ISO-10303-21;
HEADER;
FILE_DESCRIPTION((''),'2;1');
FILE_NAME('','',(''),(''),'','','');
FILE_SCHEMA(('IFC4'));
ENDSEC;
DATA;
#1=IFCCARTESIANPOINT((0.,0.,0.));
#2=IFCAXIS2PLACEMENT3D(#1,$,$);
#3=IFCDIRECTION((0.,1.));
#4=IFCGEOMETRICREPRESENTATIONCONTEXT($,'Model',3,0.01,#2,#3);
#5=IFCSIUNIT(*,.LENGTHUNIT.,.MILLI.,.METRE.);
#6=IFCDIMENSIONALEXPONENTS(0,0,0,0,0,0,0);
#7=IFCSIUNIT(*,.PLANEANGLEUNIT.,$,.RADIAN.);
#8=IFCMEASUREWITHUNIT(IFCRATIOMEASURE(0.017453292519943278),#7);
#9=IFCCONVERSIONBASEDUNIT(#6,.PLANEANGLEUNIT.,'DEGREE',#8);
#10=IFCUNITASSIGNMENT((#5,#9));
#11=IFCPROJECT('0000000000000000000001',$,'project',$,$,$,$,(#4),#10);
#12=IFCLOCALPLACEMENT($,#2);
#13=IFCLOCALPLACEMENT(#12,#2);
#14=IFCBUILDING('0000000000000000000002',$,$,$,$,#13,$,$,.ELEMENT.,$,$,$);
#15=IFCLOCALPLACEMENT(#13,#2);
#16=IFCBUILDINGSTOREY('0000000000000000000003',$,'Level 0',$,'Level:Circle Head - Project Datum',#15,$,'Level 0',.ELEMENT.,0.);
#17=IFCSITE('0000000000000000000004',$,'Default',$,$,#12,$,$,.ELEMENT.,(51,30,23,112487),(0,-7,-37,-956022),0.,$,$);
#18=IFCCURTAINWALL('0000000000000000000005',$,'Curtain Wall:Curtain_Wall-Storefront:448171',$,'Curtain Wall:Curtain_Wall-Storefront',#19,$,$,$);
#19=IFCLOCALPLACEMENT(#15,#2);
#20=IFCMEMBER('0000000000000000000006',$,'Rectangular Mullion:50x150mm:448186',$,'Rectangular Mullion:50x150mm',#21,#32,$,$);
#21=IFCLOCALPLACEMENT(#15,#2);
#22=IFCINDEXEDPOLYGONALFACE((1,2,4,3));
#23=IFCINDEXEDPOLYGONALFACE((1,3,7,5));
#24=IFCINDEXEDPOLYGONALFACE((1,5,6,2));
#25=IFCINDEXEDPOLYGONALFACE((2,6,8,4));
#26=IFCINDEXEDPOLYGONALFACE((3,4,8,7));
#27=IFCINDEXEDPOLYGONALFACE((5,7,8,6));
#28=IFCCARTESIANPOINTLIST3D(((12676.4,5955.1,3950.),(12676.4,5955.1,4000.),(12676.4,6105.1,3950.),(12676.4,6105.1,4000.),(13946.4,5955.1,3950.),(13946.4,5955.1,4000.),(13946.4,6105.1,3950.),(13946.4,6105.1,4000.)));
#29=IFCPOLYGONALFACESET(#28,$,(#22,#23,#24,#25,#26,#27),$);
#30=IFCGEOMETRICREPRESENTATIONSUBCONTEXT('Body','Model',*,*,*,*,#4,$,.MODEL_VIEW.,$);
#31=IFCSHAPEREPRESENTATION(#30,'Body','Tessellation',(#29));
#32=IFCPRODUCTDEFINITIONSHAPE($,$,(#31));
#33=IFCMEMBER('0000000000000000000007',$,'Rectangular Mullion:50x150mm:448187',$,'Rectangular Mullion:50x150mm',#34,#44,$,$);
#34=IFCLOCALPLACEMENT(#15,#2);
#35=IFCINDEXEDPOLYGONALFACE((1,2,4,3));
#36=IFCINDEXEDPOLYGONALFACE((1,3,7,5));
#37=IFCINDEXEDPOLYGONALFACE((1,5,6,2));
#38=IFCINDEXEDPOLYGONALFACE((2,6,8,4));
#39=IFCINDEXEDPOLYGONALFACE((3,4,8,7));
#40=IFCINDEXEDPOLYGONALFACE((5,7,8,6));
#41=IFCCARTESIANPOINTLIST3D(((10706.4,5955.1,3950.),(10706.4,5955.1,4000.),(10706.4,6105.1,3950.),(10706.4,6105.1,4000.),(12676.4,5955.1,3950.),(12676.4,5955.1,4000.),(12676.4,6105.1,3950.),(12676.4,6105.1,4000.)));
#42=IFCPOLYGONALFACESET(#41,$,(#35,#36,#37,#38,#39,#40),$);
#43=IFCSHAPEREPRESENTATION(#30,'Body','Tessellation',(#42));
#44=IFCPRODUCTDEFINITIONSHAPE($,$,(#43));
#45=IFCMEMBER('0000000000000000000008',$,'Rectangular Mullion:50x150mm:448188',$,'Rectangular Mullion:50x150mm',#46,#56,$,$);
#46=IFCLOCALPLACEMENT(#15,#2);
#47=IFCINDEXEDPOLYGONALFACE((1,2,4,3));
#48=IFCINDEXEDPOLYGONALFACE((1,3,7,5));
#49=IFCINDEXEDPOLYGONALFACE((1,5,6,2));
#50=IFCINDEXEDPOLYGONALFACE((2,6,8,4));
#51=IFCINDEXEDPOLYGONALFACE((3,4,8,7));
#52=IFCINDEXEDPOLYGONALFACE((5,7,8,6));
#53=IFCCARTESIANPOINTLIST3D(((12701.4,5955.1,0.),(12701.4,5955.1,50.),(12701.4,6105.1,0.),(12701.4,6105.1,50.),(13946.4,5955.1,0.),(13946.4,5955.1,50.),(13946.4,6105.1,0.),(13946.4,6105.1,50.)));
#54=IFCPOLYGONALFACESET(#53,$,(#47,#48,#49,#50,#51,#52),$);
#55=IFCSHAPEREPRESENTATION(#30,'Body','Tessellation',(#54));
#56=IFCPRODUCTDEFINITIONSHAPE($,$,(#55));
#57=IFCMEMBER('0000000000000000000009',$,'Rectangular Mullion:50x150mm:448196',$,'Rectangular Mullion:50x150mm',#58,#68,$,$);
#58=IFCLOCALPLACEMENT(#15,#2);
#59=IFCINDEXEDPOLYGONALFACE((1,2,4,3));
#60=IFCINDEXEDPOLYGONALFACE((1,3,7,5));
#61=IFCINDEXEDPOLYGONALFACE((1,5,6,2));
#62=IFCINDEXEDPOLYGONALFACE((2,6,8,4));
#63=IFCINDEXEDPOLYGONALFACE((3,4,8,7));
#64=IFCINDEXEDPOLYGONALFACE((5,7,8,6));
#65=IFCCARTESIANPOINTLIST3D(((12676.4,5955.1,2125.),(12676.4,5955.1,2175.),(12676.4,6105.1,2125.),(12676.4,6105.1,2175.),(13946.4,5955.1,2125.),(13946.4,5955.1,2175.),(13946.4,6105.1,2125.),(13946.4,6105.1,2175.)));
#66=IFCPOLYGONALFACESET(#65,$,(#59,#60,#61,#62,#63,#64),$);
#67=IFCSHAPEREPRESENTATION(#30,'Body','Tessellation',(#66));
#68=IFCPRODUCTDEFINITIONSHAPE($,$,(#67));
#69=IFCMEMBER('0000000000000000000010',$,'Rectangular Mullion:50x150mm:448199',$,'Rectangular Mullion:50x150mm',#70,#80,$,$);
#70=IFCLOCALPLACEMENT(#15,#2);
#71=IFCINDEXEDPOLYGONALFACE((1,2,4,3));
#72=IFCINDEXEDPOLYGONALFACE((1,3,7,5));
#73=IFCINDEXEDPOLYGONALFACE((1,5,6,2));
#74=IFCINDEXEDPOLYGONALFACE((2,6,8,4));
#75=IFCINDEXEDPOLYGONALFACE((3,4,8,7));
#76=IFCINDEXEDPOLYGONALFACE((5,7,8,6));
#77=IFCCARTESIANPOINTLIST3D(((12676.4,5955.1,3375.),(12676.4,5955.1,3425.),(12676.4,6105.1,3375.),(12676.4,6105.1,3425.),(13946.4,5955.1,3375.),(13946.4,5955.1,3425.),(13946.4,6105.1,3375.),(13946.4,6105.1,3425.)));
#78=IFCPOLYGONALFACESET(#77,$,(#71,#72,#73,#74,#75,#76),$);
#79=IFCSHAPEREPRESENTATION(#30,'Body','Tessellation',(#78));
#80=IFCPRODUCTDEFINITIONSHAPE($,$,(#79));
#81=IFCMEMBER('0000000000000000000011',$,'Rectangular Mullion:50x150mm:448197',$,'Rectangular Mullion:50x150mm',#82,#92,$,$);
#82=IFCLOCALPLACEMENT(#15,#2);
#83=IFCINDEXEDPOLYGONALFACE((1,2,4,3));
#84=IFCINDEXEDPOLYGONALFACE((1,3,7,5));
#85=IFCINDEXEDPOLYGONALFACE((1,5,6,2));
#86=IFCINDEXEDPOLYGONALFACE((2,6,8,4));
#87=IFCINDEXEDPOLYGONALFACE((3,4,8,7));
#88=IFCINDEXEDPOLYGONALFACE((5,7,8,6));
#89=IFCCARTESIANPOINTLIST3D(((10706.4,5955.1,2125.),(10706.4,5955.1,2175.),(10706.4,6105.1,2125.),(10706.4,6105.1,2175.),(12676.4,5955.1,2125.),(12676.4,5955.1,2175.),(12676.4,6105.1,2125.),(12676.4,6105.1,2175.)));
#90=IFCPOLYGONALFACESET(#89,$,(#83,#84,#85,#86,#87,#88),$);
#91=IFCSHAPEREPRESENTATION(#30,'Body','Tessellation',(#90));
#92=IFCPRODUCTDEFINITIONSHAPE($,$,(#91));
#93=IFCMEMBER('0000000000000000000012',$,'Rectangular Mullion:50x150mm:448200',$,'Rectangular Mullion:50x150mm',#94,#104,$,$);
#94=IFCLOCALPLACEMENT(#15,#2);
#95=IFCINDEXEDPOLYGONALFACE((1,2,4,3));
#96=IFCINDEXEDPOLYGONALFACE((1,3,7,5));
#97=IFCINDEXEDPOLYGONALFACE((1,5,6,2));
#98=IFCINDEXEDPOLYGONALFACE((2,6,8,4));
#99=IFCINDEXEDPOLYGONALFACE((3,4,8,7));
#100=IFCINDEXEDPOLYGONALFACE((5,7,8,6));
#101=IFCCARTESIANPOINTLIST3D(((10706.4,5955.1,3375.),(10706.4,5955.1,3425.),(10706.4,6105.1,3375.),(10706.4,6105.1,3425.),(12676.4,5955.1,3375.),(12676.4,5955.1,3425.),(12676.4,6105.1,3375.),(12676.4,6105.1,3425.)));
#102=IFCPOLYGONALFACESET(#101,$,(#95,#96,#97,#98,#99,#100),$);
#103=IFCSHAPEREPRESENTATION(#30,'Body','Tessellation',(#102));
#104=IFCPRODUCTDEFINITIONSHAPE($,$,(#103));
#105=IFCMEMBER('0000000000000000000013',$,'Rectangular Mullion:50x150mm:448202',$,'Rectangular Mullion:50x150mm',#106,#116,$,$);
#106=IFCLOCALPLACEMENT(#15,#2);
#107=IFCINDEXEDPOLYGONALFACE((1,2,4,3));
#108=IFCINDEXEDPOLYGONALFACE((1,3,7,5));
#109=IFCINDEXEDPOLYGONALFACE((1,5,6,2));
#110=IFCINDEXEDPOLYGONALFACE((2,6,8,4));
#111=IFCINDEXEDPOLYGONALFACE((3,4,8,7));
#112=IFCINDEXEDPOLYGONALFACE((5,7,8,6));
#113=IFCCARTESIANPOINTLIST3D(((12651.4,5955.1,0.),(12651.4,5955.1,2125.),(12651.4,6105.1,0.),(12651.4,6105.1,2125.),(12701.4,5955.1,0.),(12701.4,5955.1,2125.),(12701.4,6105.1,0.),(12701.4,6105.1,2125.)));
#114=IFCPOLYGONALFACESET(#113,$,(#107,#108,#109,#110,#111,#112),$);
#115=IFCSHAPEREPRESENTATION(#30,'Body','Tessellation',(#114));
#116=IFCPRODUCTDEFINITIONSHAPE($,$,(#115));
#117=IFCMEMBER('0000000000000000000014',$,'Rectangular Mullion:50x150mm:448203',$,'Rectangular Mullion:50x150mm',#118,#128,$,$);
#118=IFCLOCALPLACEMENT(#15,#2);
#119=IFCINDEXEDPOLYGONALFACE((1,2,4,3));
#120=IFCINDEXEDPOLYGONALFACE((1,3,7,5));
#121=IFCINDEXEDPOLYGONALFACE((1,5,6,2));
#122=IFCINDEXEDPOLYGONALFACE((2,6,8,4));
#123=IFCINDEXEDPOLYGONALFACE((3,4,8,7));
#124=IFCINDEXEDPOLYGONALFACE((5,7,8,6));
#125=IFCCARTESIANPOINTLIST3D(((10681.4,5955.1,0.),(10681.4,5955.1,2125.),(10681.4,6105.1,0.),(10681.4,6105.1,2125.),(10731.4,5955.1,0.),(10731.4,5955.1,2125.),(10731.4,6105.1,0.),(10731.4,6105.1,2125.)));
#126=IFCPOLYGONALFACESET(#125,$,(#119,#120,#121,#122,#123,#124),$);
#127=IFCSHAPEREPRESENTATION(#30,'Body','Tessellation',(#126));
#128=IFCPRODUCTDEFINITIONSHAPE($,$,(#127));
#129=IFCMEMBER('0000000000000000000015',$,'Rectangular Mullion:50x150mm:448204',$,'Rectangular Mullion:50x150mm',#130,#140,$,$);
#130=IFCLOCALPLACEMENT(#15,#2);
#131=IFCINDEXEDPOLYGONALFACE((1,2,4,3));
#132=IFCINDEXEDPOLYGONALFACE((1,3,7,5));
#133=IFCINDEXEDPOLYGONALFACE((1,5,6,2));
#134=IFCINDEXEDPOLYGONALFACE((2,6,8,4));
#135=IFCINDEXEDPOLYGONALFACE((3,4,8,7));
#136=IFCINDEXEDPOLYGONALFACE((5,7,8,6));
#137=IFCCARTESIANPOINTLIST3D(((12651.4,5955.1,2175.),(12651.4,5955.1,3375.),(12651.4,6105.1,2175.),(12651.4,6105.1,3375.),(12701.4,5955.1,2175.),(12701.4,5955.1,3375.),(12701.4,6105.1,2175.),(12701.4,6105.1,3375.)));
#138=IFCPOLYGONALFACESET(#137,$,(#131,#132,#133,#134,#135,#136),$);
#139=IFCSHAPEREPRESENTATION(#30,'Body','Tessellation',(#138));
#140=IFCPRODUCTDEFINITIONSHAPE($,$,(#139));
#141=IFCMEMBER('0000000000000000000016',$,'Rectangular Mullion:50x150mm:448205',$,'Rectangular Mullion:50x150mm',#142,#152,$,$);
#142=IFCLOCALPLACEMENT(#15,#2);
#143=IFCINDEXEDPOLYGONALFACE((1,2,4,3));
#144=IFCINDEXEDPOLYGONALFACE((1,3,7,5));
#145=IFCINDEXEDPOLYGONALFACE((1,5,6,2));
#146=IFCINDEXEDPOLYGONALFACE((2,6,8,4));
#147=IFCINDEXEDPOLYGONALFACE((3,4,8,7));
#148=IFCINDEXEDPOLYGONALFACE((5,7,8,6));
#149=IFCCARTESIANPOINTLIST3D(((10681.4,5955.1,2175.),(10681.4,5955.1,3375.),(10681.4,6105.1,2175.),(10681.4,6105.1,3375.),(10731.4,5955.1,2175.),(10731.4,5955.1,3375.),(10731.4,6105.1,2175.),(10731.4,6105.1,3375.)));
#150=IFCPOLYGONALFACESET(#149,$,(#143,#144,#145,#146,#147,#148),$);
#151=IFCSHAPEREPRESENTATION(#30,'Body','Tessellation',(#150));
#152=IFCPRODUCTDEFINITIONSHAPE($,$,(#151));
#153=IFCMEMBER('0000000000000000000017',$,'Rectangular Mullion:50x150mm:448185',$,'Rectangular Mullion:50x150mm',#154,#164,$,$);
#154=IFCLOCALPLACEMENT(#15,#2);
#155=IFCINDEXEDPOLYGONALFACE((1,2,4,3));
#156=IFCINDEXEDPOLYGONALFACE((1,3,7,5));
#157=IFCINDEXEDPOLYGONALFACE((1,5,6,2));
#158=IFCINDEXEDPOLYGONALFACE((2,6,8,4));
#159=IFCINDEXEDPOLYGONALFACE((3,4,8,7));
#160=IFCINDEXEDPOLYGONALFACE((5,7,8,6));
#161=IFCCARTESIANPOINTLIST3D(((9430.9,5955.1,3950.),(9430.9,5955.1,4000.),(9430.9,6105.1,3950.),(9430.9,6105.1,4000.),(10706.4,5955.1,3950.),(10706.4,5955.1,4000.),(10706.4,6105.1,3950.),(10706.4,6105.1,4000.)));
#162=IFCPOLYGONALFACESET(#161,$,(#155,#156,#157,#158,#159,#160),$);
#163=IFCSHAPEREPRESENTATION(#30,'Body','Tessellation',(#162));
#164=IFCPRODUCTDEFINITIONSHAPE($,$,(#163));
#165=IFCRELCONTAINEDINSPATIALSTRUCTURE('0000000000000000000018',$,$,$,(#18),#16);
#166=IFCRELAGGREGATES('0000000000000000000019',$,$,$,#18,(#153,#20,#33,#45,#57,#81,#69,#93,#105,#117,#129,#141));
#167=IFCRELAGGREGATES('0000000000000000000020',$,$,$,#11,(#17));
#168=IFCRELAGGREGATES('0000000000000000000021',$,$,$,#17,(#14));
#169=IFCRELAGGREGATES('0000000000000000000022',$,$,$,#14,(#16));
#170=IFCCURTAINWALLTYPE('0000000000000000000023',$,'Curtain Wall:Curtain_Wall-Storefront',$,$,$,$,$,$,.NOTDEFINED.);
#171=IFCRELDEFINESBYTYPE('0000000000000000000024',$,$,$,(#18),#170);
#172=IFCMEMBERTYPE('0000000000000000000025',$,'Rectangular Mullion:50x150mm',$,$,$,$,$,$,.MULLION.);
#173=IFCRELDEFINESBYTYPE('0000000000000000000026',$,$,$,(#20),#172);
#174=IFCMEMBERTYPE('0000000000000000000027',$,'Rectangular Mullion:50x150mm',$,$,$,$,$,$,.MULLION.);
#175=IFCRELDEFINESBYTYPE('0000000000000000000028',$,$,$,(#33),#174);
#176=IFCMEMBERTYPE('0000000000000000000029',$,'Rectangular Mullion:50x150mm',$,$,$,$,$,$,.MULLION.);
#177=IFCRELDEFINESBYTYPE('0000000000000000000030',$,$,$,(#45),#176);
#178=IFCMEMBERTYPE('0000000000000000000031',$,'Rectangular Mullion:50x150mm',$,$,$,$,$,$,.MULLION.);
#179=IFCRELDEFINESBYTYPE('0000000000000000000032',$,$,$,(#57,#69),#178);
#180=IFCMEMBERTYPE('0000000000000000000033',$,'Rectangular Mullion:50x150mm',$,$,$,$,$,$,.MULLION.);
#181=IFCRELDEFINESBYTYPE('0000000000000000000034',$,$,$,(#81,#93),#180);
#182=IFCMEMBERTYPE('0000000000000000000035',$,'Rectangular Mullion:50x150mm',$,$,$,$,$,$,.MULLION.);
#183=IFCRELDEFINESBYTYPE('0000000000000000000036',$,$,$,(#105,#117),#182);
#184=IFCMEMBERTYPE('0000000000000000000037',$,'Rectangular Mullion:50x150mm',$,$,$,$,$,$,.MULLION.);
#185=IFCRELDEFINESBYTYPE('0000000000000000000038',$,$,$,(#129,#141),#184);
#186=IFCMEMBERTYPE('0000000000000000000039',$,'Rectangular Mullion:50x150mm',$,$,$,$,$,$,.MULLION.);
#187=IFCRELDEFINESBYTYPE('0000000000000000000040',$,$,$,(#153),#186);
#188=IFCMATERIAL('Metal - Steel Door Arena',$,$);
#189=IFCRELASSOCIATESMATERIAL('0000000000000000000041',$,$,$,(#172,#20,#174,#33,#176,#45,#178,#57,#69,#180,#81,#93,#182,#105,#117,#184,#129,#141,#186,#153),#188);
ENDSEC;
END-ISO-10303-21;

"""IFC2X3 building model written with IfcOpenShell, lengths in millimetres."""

from ifc_helpers import new_model, entity, si_unit, converted_unit, direction, frame, origin, origin_2d_with_axis, place, context, subcontext, project, spatial, rectangle, extrude, source, transform, mapped, material, type_object, type_shapes, element, aggregate, save


model = new_model("IFC2X3")

# Units and contexts
model_context = context("Model", 3, precision=0.01, world=origin(), true_north=direction((0.0, 1.0)))
body_context = subcontext(model_context, "Body", "Model", "MODEL_VIEW")
ifc_project = project(units=[si_unit("LENGTHUNIT", "METRE", prefix="MILLI"), converted_unit("PLANEANGLEUNIT", "DEGREE", entity("IfcRatioMeasure", 0.017453292519943278), si_unit("PLANEANGLEUNIT", "RADIAN"), dimensions=[0, 0, 0, 0, 0, 0, 0])], contexts=[model_context])

# Site, building, storey
site_placement = place(None, origin())
site = spatial("IfcSite", under=ifc_project, at=site_placement, Name="Default", CompositionType="ELEMENT", RefLatitude=(51, 30, 23, 112487), RefLongitude=(0, -7, -37, -956022), RefElevation=0.0)
building_placement = place(site_placement, origin())
building = spatial("IfcBuilding", under=site, at=building_placement, CompositionType="ELEMENT")
storey_placement = place(building_placement, origin())
storey = spatial("IfcBuildingStorey", under=building, at=storey_placement, Name="Level 0", ObjectType="Level:Circle Head - Project Datum", LongName="Level 0", CompositionType="ELEMENT", Elevation=0.0)

# Curtain wall, members
curtain_wall_type = type_object("IfcCurtainWallType", Name="Curtain Wall:Curtain_Wall-Storefront", PredefinedType="NOTDEFINED")
curtain_wall_placement = place(storey_placement, origin())
curtain_wall = element("IfcCurtainWall", 1, at=curtain_wall_placement, inside=storey, type_object=curtain_wall_type, Name="Curtain Wall:Curtain_Wall-Storefront:448171", ObjectType="Curtain Wall:Curtain_Wall-Storefront")
ifc_material_1 = material(Name="Metal - Steel Door Arena")
member_type_1 = type_object("IfcMemberType", Name="Rectangular Mullion:50x150mm", PredefinedType="MULLION", material=ifc_material_1)
shared_shape_1 = source(origin(), body_context, "Body", "SweptSolid", [
    extrude(rectangle(XDim=150.0, YDim=50.0, at=origin_2d_with_axis()), frame((-25.0, 0.0, -1270.0), z_axis=(0.0, 0.0, 1.0), x_axis=(0.0, -1.0, 0.0)), (0.0, 0.0, 1.0), 1270.0),
])
type_shapes(member_type_1, [shared_shape_1])
member_1_placement = place(curtain_wall_placement, frame((12676.4, 6030.1, 4000.0), z_axis=(-1.0, 0.0, 0.0), x_axis=(0.0, 0.0, 1.0)))
member_1 = element("IfcMember", 2, at=member_1_placement, type_object=member_type_1, material=ifc_material_1, Name="Rectangular Mullion:50x150mm:448186", ObjectType="Rectangular Mullion:50x150mm", context=body_context, shape_type="MappedRepresentation", body=[
    mapped(shared_shape_1, transform((0.0, 0.0, 0.0), scale=1.0)),
])
member_type_2 = type_object("IfcMemberType", Name="Rectangular Mullion:50x150mm", PredefinedType="MULLION", material=ifc_material_1)
shared_shape_2 = source(origin(), body_context, "Body", "SweptSolid", [
    extrude(rectangle(XDim=150.0, YDim=50.0, at=origin_2d_with_axis()), frame((-25.0, 0.0, -1970.0), z_axis=(0.0, 0.0, 1.0), x_axis=(0.0, -1.0, 0.0)), (0.0, 0.0, 1.0), 1970.0),
])
type_shapes(member_type_2, [shared_shape_2])
member_2_placement = place(curtain_wall_placement, frame((10706.4, 6030.1, 4000.0), z_axis=(-1.0, 0.0, 0.0), x_axis=(0.0, 0.0, 1.0)))
member_2 = element("IfcMember", 3, at=member_2_placement, type_object=member_type_2, material=ifc_material_1, Name="Rectangular Mullion:50x150mm:448187", ObjectType="Rectangular Mullion:50x150mm", context=body_context, shape_type="MappedRepresentation", body=[
    mapped(shared_shape_2, transform((0.0, 0.0, 0.0), scale=1.0)),
])
member_type_3 = type_object("IfcMemberType", Name="Rectangular Mullion:50x150mm", PredefinedType="MULLION", material=ifc_material_1)
shared_shape_3 = source(origin(), body_context, "Body", "SweptSolid", [
    extrude(rectangle(XDim=150.0, YDim=50.0, at=origin_2d_with_axis()), frame((-25.0, 0.0, -1245.0), z_axis=(0.0, 0.0, 1.0), x_axis=(0.0, -1.0, 0.0)), (0.0, 0.0, 1.0), 1245.0),
])
type_shapes(member_type_3, [shared_shape_3])
member_3_placement = place(curtain_wall_placement, frame((13946.4, 6030.1, 0.0), z_axis=(1.0, 0.0, 0.0), x_axis=(0.0, 0.0, -1.0)))
member_3 = element("IfcMember", 4, at=member_3_placement, type_object=member_type_3, material=ifc_material_1, Name="Rectangular Mullion:50x150mm:448188", ObjectType="Rectangular Mullion:50x150mm", context=body_context, shape_type="MappedRepresentation", body=[
    mapped(shared_shape_3, transform((0.0, 0.0, 0.0), scale=1.0)),
])
member_type_4 = type_object("IfcMemberType", Name="Rectangular Mullion:50x150mm", PredefinedType="MULLION", material=ifc_material_1)
shared_shape_4 = source(origin(), body_context, "Body", "SweptSolid", [
    extrude(rectangle(XDim=150.0, YDim=50.0, at=origin_2d_with_axis()), frame((0.0, 0.0, -1270.0), z_axis=(0.0, 0.0, 1.0), x_axis=(0.0, -1.0, 0.0)), (0.0, 0.0, 1.0), 1270.0),
])
type_shapes(member_type_4, [shared_shape_4])
member_4_placement = place(curtain_wall_placement, frame((12676.4, 6030.1, 2150.0), z_axis=(-1.0, 0.0, 0.0), x_axis=(0.0, 0.0, 1.0)))
member_4 = element("IfcMember", 5, at=member_4_placement, type_object=member_type_4, material=ifc_material_1, Name="Rectangular Mullion:50x150mm:448196", ObjectType="Rectangular Mullion:50x150mm", context=body_context, shape_type="MappedRepresentation", body=[
    mapped(shared_shape_4, transform((0.0, 0.0, 0.0), scale=1.0)),
])
member_5_placement = place(curtain_wall_placement, frame((12676.4, 6030.1, 3400.0), z_axis=(-1.0, 0.0, 0.0), x_axis=(0.0, 0.0, 1.0)))
member_5 = element("IfcMember", 6, at=member_5_placement, type_object=member_type_4, material=ifc_material_1, Name="Rectangular Mullion:50x150mm:448199", ObjectType="Rectangular Mullion:50x150mm", context=body_context, shape_type="MappedRepresentation", body=[
    mapped(shared_shape_4, transform((0.0, 0.0, 0.0), scale=1.0)),
])
member_type_5 = type_object("IfcMemberType", Name="Rectangular Mullion:50x150mm", PredefinedType="MULLION", material=ifc_material_1)
shared_shape_5 = source(origin(), body_context, "Body", "SweptSolid", [
    extrude(rectangle(XDim=150.0, YDim=50.0, at=origin_2d_with_axis()), frame((0.0, 0.0, -1970.0), z_axis=(0.0, 0.0, 1.0), x_axis=(0.0, -1.0, 0.0)), (0.0, 0.0, 1.0), 1970.0),
])
type_shapes(member_type_5, [shared_shape_5])
member_6_placement = place(curtain_wall_placement, frame((10706.4, 6030.1, 2150.0), z_axis=(-1.0, 0.0, 0.0), x_axis=(0.0, 0.0, 1.0)))
member_6 = element("IfcMember", 7, at=member_6_placement, type_object=member_type_5, material=ifc_material_1, Name="Rectangular Mullion:50x150mm:448197", ObjectType="Rectangular Mullion:50x150mm", context=body_context, shape_type="MappedRepresentation", body=[
    mapped(shared_shape_5, transform((0.0, 0.0, 0.0), scale=1.0)),
])
member_7_placement = place(curtain_wall_placement, frame((10706.4, 6030.1, 3400.0), z_axis=(-1.0, 0.0, 0.0), x_axis=(0.0, 0.0, 1.0)))
member_7 = element("IfcMember", 8, at=member_7_placement, type_object=member_type_5, material=ifc_material_1, Name="Rectangular Mullion:50x150mm:448200", ObjectType="Rectangular Mullion:50x150mm", context=body_context, shape_type="MappedRepresentation", body=[
    mapped(shared_shape_5, transform((0.0, 0.0, 0.0), scale=1.0)),
])
member_type_6 = type_object("IfcMemberType", Name="Rectangular Mullion:50x150mm", PredefinedType="MULLION", material=ifc_material_1)
shared_shape_6 = source(origin(), body_context, "Body", "SweptSolid", [
    extrude(rectangle(XDim=150.0, YDim=50.0, at=origin_2d_with_axis()), frame((0.0, 0.0, -2125.0), z_axis=(0.0, 0.0, 1.0), x_axis=(0.0, -1.0, 0.0)), (0.0, 0.0, 1.0), 2125.0),
])
type_shapes(member_type_6, [shared_shape_6])
member_8_placement = place(curtain_wall_placement, frame((12676.4, 6030.1, 0.0), z_axis=(0.0, 0.0, -1.0), x_axis=(-1.0, 0.0, 0.0)))
member_8 = element("IfcMember", 9, at=member_8_placement, type_object=member_type_6, material=ifc_material_1, Name="Rectangular Mullion:50x150mm:448202", ObjectType="Rectangular Mullion:50x150mm", context=body_context, shape_type="MappedRepresentation", body=[
    mapped(shared_shape_6, transform((0.0, 0.0, 0.0), scale=1.0)),
])
member_9_placement = place(curtain_wall_placement, frame((10706.4, 6030.1, 0.0), z_axis=(0.0, 0.0, -1.0), x_axis=(-1.0, 0.0, 0.0)))
member_9 = element("IfcMember", 10, at=member_9_placement, type_object=member_type_6, material=ifc_material_1, Name="Rectangular Mullion:50x150mm:448203", ObjectType="Rectangular Mullion:50x150mm", context=body_context, shape_type="MappedRepresentation", body=[
    mapped(shared_shape_6, transform((0.0, 0.0, 0.0), scale=1.0)),
])
member_type_7 = type_object("IfcMemberType", Name="Rectangular Mullion:50x150mm", PredefinedType="MULLION", material=ifc_material_1)
shared_shape_7 = source(origin(), body_context, "Body", "SweptSolid", [
    extrude(rectangle(XDim=150.0, YDim=50.0, at=origin_2d_with_axis()), frame((0.0, 0.0, -1200.0), z_axis=(0.0, 0.0, 1.0), x_axis=(0.0, -1.0, 0.0)), (0.0, 0.0, 1.0), 1200.0),
])
type_shapes(member_type_7, [shared_shape_7])
member_10_placement = place(curtain_wall_placement, frame((12676.4, 6030.1, 2175.0), z_axis=(0.0, 0.0, -1.0), x_axis=(-1.0, 0.0, 0.0)))
member_10 = element("IfcMember", 11, at=member_10_placement, type_object=member_type_7, material=ifc_material_1, Name="Rectangular Mullion:50x150mm:448204", ObjectType="Rectangular Mullion:50x150mm", context=body_context, shape_type="MappedRepresentation", body=[
    mapped(shared_shape_7, transform((0.0, 0.0, 0.0), scale=1.0)),
])
member_11_placement = place(curtain_wall_placement, frame((10706.4, 6030.1, 2175.0), z_axis=(0.0, 0.0, -1.0), x_axis=(-1.0, 0.0, 0.0)))
member_11 = element("IfcMember", 12, at=member_11_placement, type_object=member_type_7, material=ifc_material_1, Name="Rectangular Mullion:50x150mm:448205", ObjectType="Rectangular Mullion:50x150mm", context=body_context, shape_type="MappedRepresentation", body=[
    mapped(shared_shape_7, transform((0.0, 0.0, 0.0), scale=1.0)),
])
member_type_8 = type_object("IfcMemberType", Name="Rectangular Mullion:50x150mm", PredefinedType="MULLION", material=ifc_material_1)
shared_shape_8 = source(origin(), body_context, "Body", "SweptSolid", [
    extrude(rectangle(XDim=150.0, YDim=50.0, at=origin_2d_with_axis()), frame((-25.0, 0.0, -1275.5), z_axis=(0.0, 0.0, 1.0), x_axis=(0.0, -1.0, 0.0)), (0.0, 0.0, 1.0), 1275.5),
])
type_shapes(member_type_8, [shared_shape_8])
member_12_placement = place(curtain_wall_placement, frame((9430.9, 6030.1, 4000.0), z_axis=(-1.0, 0.0, 0.0), x_axis=(0.0, 0.0, 1.0)))
member_12 = element("IfcMember", 13, at=member_12_placement, type_object=member_type_8, material=ifc_material_1, Name="Rectangular Mullion:50x150mm:448185", ObjectType="Rectangular Mullion:50x150mm", context=body_context, shape_type="MappedRepresentation", body=[
    mapped(shared_shape_8, transform((0.0, 0.0, 0.0), scale=1.0)),
])
aggregate(curtain_wall, [member_12, member_1, member_2, member_3, member_4, member_6, member_5, member_7, member_8, member_9, member_10, member_11])

save(model, "model.ifc")
